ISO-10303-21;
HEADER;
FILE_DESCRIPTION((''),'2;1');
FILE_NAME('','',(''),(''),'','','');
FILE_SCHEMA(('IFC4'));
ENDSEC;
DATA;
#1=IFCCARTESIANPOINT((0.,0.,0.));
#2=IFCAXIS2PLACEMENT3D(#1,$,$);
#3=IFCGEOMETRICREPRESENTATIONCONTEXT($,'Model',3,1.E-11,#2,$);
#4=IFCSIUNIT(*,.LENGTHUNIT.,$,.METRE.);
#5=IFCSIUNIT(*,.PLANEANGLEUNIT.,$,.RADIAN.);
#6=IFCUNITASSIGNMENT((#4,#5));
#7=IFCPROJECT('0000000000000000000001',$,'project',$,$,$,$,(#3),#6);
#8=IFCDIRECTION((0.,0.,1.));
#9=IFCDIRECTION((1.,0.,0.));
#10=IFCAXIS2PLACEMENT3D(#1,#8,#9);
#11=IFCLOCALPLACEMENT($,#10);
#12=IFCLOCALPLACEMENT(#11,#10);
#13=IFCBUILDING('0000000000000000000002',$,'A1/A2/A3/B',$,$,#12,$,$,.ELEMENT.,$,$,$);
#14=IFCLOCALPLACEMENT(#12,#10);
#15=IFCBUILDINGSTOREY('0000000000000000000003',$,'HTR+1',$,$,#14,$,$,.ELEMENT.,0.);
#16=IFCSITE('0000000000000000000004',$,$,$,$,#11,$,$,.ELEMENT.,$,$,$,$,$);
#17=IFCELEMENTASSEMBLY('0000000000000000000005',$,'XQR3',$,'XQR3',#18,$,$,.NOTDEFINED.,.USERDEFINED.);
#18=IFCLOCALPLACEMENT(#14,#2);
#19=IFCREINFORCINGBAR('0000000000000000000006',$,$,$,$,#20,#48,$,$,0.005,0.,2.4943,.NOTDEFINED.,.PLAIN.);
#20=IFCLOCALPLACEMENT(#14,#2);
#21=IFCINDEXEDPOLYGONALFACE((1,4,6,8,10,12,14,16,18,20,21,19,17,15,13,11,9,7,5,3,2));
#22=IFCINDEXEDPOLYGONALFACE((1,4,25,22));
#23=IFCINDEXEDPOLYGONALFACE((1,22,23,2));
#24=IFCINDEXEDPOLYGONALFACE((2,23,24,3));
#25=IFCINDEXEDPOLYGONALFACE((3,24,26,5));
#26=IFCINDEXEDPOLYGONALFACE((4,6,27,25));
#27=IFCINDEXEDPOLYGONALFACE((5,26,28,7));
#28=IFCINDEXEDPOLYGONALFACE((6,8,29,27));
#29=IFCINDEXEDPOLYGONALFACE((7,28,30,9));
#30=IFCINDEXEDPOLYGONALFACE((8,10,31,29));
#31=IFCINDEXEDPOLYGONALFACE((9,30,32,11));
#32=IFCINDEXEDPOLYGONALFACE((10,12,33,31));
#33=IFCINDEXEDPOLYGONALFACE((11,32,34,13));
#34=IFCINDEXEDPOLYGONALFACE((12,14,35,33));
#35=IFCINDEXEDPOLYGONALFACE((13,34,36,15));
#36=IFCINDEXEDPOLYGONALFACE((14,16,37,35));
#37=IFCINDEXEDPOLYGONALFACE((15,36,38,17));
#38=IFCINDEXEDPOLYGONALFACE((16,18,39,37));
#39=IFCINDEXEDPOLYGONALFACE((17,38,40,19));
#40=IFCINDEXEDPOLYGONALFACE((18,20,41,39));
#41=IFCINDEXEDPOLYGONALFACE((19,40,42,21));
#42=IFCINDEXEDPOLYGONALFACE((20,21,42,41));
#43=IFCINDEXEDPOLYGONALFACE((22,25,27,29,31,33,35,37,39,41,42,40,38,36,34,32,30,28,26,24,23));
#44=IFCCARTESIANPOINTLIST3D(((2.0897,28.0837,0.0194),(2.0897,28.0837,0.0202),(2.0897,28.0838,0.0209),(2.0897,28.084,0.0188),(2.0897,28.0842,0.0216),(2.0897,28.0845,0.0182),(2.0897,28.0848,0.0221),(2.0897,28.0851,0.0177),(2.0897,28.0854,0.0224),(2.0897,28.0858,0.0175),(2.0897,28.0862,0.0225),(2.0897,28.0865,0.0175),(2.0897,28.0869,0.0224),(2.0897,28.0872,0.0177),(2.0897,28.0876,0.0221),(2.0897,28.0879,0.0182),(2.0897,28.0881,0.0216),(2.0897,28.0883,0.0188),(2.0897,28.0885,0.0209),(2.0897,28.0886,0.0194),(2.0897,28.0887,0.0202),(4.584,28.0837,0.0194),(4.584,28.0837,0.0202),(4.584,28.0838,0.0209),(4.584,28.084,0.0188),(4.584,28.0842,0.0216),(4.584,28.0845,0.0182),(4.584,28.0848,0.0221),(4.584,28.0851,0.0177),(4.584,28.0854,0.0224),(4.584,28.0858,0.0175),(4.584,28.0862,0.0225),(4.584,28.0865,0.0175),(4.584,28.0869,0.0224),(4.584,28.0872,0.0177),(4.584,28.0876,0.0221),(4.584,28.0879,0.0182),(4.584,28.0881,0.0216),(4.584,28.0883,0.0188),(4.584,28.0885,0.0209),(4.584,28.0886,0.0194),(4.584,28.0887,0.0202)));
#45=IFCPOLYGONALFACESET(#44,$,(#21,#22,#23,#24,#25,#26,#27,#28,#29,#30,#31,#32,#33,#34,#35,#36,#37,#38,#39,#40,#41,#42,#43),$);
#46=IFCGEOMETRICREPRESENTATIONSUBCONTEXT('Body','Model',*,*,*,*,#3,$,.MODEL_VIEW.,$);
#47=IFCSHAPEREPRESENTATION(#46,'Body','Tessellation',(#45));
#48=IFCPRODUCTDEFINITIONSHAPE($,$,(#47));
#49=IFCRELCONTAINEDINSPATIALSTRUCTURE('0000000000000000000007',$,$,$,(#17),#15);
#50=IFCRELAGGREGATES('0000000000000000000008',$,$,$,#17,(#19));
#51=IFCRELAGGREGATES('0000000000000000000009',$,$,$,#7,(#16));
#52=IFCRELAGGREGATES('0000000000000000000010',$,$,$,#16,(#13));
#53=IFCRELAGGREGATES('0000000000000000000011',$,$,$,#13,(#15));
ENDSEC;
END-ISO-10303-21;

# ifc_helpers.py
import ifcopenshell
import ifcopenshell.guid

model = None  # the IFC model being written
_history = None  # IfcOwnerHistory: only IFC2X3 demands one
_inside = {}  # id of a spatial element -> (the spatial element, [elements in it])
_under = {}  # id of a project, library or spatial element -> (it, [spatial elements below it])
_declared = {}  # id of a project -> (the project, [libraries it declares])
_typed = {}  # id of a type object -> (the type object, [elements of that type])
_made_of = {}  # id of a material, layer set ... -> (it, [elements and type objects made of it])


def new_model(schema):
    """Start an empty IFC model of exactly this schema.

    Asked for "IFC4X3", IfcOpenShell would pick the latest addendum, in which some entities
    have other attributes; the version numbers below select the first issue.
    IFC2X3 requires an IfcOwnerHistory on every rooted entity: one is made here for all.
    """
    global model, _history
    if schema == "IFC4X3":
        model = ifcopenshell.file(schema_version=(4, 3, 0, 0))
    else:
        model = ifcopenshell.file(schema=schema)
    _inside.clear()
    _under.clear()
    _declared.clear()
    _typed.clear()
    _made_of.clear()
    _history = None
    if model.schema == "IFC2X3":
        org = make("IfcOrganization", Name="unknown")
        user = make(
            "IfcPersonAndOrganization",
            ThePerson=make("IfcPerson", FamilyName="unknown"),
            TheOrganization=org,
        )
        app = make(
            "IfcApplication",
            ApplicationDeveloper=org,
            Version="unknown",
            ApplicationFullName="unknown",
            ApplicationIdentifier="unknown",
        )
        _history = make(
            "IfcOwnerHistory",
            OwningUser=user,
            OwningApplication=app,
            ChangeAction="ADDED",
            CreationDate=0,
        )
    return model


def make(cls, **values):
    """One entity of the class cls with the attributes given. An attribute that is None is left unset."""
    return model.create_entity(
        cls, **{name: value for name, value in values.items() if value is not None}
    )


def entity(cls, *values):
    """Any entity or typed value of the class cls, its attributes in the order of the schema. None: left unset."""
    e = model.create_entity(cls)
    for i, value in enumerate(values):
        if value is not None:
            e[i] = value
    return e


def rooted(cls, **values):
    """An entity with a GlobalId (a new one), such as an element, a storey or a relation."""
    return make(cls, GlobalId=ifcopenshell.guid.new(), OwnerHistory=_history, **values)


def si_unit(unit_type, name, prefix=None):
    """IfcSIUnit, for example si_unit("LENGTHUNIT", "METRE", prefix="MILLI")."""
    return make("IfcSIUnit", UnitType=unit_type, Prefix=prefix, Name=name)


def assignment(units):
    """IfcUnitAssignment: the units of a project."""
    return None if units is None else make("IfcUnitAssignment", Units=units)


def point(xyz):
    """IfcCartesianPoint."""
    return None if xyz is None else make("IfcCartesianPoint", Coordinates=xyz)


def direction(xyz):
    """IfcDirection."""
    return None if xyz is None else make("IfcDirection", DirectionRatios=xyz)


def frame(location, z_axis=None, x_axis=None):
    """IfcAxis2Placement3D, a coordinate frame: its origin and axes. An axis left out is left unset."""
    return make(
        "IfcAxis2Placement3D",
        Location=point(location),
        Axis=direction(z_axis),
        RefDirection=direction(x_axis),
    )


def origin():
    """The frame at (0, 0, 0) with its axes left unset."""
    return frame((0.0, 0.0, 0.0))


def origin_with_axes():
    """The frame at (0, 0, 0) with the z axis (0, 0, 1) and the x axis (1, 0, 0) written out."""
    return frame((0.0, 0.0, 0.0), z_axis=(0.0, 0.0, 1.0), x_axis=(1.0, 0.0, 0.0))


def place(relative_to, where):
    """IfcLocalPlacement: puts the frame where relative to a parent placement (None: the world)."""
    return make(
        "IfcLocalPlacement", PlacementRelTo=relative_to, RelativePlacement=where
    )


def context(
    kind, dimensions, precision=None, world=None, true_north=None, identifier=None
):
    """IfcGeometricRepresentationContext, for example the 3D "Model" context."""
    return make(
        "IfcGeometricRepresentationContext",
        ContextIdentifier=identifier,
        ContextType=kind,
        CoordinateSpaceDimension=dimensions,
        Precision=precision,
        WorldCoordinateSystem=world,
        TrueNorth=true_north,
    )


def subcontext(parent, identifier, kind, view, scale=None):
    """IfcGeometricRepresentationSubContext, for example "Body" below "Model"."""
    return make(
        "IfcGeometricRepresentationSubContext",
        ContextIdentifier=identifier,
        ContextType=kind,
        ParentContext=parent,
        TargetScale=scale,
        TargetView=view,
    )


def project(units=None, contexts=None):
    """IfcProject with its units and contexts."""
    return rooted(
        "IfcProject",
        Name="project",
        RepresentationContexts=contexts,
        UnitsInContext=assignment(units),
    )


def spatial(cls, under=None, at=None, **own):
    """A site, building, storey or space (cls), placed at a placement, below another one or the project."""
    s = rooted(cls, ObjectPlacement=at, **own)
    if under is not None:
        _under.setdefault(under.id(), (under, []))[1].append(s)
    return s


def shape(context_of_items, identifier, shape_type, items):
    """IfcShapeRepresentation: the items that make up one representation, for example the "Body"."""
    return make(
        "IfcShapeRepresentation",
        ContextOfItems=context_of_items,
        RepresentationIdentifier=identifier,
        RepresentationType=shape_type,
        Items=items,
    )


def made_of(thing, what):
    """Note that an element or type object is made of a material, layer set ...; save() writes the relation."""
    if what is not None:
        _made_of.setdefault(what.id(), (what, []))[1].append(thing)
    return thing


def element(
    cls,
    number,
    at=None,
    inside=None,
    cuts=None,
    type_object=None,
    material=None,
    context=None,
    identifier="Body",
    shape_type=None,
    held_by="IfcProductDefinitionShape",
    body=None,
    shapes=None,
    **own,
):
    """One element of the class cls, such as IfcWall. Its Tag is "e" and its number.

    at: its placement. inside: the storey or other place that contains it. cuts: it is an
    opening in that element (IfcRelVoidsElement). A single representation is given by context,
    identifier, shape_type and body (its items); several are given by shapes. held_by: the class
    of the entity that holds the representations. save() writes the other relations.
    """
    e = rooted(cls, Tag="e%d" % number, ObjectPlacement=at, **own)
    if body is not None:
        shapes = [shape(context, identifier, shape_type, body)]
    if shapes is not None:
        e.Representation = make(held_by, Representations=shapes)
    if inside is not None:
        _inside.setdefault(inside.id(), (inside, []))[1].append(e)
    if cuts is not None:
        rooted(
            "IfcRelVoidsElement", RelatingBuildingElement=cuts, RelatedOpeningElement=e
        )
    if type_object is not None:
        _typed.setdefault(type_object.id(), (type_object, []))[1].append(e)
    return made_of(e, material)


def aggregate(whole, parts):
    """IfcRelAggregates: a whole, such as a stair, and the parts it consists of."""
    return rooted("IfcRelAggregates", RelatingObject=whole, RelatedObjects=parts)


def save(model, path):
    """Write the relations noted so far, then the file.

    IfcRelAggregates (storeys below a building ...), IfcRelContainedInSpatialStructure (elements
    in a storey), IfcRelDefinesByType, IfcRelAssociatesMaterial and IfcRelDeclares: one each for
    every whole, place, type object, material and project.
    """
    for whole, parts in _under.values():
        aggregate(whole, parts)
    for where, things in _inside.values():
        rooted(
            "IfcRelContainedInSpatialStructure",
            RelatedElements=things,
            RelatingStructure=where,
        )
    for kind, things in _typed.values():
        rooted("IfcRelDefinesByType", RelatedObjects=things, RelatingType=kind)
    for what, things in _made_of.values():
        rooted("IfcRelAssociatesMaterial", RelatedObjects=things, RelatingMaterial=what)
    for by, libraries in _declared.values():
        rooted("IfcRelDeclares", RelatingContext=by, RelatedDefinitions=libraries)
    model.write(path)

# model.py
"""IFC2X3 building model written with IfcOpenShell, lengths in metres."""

from ifc_helpers import new_model, entity, si_unit, origin, origin_with_axes, place, context, subcontext, project, spatial, shape, element, aggregate, save


model = new_model("IFC2X3")

# Units and contexts
model_context = context("Model", 3, precision=1e-11, world=origin())
body_context = subcontext(model_context, "Body", "Model", "MODEL_VIEW")
ifc_project = project(units=[si_unit("LENGTHUNIT", "METRE"), si_unit("PLANEANGLEUNIT", "RADIAN")], contexts=[model_context])

# Site, building, storey
site_placement = place(None, origin_with_axes())
site = spatial("IfcSite", under=ifc_project, at=site_placement, CompositionType="ELEMENT")
building_placement = place(site_placement, origin_with_axes())
building = spatial("IfcBuilding", under=site, at=building_placement, Name="A1/A2/A3/B", CompositionType="ELEMENT")
storey_placement = place(building_placement, origin_with_axes())
storey = spatial("IfcBuildingStorey", under=building, at=storey_placement, Name="HTR+1", CompositionType="ELEMENT", Elevation=0.0)

# Element assembly, reinforcing bar
assembly_1_placement = place(storey_placement, origin_with_axes())
assembly_1 = element("IfcElementAssembly", 1, at=assembly_1_placement, inside=storey, Name="XQR3", ObjectType="XQR3", AssemblyPlace="NOTDEFINED", PredefinedType="USERDEFINED")
reinforcing_bar_1_placement = place(assembly_1_placement, origin_with_axes())
reinforcing_bar_1 = element("IfcReinforcingBar", 2, at=reinforcing_bar_1_placement, BarLength=2.4943, BarRole="NOTDEFINED", BarSurface="PLAIN", CrossSectionArea=0.0, NominalDiameter=0.005, shapes=[
    shape(body_context, "Body", "AdvancedSweptSolid", [entity("IfcSweptDiskSolid", entity("IfcPolyline", [entity("IfcCartesianPoint", [2.0897, 28.0862, 0.02]), entity("IfcCartesianPoint", [4.584, 28.0862, 0.02])]), 0.0025, None, 0.0, 2.4943)]),
    shape(body_context, "Body", "AdvancedSweptSolid", [entity("IfcSweptDiskSolid", entity("IfcPolyline", [entity("IfcCartesianPoint", [2.0897, 28.0862, 0.02]), entity("IfcCartesianPoint", [4.584, 28.0862, 0.02])]), 0.0025, None, 0.0, 2.4943)]),
])
aggregate(assembly_1, [reinforcing_bar_1])

save(model, "model.ifc")
